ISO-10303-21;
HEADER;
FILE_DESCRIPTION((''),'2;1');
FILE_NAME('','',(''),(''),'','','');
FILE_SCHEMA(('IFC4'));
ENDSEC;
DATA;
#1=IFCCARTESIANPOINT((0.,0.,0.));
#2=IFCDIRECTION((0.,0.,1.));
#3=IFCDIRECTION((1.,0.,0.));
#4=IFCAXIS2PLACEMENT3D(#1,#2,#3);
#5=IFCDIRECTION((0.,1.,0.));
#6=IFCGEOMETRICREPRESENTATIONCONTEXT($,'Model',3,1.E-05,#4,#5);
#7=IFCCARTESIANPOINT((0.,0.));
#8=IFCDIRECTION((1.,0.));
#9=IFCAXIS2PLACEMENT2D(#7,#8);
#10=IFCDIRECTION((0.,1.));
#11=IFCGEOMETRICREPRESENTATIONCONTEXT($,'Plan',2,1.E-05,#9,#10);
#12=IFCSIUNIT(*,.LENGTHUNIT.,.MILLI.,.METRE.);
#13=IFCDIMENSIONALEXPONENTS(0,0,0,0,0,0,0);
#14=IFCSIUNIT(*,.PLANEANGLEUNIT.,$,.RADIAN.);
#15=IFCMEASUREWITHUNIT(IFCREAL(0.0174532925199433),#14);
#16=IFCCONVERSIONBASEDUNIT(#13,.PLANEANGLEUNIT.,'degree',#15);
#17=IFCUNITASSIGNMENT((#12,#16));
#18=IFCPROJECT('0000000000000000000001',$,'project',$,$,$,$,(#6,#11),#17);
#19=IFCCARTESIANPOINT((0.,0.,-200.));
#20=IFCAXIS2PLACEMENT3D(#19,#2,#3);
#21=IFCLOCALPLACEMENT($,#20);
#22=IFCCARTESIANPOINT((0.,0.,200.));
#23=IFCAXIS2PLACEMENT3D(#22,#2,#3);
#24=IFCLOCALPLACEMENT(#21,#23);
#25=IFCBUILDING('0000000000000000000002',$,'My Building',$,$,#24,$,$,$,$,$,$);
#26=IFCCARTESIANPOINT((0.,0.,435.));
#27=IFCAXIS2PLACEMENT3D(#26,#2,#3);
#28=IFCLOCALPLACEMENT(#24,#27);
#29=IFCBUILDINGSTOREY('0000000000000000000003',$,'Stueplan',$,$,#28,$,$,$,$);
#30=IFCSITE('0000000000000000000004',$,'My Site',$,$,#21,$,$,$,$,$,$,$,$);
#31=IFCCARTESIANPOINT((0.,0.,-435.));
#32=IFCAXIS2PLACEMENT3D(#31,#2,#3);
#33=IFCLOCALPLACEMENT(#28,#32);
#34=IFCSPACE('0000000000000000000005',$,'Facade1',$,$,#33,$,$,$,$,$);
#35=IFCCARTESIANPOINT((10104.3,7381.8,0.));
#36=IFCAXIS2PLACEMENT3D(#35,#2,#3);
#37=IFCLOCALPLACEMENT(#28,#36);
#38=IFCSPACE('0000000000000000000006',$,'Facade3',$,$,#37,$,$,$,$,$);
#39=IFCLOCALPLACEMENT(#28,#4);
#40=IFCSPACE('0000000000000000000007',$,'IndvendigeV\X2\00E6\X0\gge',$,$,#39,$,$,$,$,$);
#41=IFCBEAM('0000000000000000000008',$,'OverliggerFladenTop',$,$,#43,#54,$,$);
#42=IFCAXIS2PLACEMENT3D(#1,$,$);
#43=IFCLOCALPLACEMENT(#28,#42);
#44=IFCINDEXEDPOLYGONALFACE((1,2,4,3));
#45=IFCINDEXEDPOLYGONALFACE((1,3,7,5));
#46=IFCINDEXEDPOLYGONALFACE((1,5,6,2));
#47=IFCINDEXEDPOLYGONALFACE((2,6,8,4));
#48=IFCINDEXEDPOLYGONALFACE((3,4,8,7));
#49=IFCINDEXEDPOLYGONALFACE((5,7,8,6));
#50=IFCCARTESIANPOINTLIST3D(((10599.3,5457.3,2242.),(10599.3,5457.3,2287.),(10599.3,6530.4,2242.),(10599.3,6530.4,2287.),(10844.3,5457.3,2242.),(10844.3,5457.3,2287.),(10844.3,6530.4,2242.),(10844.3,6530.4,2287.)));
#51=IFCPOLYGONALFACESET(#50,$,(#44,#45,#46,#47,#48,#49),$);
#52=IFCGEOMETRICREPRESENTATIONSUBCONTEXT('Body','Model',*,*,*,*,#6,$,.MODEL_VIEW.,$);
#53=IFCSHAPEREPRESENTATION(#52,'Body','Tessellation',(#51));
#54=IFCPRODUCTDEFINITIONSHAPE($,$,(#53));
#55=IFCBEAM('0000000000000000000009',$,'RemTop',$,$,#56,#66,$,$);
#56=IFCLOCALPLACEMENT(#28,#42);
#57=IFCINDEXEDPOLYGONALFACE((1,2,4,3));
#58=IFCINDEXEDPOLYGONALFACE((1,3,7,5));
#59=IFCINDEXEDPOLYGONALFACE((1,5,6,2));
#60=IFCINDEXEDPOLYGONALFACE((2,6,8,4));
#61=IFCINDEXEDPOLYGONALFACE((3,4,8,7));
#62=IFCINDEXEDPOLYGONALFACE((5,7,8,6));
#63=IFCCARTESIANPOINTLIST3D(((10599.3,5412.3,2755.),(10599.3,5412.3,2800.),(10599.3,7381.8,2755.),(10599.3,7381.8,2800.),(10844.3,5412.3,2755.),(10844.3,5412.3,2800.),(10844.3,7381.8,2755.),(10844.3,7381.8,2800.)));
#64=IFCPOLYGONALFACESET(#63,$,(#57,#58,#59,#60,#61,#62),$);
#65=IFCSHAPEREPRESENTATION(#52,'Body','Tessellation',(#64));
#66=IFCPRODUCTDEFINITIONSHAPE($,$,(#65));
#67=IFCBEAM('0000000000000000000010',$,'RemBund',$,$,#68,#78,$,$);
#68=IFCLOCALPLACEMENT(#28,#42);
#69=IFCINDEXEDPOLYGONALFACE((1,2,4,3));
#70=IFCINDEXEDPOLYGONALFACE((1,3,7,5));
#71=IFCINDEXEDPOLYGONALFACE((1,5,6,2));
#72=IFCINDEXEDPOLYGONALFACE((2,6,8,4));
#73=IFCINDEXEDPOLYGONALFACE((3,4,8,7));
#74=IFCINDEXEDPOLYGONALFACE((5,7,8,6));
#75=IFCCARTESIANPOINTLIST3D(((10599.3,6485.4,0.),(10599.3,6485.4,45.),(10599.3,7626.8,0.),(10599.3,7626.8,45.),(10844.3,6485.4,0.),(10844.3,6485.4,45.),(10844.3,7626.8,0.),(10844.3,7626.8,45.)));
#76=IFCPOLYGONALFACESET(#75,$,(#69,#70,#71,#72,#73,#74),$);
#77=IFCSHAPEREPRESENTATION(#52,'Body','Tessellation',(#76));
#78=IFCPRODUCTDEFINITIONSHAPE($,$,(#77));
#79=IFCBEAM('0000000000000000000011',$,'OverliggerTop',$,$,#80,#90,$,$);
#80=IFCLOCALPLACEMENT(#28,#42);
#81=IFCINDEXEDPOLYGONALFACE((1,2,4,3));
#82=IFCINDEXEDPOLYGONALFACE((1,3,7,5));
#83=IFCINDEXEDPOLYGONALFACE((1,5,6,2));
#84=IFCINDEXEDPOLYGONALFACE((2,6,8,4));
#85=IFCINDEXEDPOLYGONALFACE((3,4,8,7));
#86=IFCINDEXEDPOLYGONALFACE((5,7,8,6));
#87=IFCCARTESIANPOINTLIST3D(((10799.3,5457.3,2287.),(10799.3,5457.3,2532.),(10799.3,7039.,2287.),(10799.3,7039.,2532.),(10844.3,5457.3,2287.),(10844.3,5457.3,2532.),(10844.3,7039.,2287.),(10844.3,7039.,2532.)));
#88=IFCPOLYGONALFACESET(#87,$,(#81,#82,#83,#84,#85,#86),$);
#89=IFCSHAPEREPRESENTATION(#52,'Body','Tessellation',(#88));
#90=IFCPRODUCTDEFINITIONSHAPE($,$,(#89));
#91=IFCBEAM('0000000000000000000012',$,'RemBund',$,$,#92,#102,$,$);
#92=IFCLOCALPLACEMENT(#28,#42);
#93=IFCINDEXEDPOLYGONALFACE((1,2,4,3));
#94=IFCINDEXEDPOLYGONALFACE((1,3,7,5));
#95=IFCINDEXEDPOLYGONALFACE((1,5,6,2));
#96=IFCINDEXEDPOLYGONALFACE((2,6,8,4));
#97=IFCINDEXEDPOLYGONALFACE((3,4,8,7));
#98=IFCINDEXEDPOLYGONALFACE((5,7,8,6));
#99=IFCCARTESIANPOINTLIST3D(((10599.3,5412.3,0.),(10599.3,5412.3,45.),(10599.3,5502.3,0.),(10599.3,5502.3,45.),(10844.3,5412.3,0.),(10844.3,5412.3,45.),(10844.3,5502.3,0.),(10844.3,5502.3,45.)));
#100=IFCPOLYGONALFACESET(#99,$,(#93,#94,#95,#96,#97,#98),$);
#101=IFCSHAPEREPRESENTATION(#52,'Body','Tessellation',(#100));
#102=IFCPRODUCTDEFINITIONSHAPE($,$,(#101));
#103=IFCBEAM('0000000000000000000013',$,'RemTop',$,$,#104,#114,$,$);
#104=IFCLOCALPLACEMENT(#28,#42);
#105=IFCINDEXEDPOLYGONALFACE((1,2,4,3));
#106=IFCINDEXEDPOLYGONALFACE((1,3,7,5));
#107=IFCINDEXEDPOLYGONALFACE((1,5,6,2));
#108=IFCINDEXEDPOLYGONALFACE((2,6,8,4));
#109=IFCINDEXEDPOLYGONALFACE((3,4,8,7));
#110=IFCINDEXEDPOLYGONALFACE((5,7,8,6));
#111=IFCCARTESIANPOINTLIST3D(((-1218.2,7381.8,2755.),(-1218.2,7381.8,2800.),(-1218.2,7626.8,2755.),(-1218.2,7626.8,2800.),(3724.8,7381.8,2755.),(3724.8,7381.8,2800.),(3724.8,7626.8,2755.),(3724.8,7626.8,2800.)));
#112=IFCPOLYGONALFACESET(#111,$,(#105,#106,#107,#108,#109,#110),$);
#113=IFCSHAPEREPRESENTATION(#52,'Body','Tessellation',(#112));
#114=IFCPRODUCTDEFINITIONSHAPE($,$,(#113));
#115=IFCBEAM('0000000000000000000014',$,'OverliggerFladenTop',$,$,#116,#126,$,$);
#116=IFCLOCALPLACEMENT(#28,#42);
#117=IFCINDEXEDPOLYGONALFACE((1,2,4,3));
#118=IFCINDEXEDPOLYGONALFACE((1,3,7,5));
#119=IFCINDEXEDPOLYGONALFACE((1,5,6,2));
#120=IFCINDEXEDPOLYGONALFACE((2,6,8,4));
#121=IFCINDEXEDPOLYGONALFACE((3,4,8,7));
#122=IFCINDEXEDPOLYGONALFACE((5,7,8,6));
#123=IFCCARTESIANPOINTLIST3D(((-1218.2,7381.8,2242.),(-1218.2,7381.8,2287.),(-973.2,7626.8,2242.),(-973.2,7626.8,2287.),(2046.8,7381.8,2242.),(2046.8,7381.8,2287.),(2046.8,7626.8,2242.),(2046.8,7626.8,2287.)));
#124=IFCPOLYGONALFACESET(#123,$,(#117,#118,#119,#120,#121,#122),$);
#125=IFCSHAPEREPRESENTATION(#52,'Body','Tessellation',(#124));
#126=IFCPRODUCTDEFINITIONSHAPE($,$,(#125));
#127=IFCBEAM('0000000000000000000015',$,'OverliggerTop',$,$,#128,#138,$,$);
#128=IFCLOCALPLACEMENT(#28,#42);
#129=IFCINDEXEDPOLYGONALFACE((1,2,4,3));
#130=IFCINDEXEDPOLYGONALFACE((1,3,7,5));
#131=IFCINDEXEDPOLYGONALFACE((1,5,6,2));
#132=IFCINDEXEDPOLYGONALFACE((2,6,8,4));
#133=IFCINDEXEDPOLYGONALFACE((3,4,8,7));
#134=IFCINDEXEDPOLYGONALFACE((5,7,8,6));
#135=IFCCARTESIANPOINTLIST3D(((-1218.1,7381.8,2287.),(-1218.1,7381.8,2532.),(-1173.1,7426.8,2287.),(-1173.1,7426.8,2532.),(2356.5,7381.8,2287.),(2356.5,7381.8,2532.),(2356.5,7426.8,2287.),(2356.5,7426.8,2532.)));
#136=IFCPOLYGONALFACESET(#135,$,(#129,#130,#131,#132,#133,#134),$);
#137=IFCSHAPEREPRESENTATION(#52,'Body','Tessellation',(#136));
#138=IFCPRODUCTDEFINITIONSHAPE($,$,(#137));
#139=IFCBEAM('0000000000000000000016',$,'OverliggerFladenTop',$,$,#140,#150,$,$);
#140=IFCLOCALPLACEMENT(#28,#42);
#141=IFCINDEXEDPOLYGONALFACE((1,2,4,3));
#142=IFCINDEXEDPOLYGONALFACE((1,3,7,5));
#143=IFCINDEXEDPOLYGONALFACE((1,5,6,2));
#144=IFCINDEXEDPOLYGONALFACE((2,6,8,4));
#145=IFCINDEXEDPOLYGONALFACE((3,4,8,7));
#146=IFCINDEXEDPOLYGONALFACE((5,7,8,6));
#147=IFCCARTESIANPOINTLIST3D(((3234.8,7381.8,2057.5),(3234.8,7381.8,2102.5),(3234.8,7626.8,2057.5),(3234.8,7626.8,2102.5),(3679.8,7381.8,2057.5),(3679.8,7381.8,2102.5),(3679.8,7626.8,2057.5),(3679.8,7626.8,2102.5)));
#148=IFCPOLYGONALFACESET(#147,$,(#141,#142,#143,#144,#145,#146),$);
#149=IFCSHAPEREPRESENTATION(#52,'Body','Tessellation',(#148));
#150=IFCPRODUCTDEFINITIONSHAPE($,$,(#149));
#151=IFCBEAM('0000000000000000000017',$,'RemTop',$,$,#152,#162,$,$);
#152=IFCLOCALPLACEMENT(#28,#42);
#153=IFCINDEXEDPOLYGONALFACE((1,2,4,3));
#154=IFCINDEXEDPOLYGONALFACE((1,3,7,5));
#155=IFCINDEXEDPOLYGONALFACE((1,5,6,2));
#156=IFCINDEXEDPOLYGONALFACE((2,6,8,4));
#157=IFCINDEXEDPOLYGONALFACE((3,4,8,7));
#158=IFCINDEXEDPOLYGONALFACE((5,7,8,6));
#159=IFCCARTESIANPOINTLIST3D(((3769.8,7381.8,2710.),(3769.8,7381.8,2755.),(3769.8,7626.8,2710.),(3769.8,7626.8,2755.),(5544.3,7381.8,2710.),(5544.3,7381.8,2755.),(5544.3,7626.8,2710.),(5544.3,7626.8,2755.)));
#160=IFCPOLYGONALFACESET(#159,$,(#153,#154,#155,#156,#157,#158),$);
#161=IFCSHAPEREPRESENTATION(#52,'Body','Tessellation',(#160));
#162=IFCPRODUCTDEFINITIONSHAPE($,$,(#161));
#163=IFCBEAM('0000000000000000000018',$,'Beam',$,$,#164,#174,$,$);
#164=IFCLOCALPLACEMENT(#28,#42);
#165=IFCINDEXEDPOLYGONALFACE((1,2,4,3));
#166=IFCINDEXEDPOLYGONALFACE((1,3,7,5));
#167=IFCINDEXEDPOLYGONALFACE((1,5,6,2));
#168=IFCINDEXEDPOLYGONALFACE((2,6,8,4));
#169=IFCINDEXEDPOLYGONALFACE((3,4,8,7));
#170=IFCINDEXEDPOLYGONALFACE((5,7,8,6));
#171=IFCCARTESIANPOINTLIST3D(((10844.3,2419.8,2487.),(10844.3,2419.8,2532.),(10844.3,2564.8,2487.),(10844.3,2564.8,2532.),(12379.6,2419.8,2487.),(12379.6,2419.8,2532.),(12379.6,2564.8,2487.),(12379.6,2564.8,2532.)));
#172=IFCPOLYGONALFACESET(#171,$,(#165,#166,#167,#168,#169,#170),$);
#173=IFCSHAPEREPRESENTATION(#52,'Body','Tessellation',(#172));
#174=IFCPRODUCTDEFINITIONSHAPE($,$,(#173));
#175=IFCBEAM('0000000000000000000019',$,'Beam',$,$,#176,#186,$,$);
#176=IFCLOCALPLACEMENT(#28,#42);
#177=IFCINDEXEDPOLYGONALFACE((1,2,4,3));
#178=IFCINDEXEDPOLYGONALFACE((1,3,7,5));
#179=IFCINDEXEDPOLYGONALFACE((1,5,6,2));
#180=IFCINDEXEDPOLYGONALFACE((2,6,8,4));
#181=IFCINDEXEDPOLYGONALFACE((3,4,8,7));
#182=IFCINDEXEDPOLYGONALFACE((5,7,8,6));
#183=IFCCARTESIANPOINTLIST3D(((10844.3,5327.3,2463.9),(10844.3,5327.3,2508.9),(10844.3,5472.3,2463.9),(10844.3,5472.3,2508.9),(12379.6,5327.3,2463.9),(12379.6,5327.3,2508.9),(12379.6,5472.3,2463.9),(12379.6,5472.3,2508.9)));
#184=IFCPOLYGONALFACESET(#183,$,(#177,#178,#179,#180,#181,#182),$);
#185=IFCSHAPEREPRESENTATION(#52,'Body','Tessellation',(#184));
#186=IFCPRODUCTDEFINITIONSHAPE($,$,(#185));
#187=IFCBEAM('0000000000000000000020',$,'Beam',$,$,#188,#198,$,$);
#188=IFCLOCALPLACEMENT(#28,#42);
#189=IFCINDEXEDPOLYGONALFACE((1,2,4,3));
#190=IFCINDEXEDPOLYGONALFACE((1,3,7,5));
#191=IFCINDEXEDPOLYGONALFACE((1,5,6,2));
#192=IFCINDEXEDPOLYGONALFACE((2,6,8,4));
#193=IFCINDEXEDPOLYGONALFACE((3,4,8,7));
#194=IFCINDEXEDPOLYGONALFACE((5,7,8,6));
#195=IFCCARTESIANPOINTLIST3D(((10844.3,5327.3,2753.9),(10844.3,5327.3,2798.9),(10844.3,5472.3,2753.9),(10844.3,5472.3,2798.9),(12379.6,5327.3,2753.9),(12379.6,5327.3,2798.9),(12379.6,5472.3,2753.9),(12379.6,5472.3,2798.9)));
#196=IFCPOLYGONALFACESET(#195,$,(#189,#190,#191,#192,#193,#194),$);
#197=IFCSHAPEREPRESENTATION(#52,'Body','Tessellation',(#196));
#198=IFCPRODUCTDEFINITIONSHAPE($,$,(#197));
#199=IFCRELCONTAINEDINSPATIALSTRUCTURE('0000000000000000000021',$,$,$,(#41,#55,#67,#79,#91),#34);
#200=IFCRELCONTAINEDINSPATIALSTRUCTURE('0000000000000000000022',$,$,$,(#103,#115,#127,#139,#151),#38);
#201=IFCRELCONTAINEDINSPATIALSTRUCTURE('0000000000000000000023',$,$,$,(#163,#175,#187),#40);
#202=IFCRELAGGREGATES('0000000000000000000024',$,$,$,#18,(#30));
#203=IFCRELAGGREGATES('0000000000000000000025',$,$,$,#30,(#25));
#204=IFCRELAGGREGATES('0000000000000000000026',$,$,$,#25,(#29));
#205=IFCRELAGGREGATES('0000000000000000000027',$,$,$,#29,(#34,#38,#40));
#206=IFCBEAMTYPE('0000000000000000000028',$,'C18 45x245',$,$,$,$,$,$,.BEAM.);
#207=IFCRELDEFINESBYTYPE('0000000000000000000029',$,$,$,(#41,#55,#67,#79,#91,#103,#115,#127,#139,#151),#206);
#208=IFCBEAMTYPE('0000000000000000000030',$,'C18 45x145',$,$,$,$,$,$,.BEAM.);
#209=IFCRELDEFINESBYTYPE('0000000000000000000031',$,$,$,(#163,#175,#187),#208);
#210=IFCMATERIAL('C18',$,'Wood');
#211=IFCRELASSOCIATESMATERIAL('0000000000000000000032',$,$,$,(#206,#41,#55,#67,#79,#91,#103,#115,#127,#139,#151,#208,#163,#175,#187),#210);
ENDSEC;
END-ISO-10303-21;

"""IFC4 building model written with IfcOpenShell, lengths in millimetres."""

from ifc_helpers import new_model, entity, si_unit, converted_unit, direction, frame, origin_with_axes, origin_2d_with_axis, place, context, subcontext, project, spatial, rectangle, extrude, clip, halfspace, material, material_profile, profile_set, profile_usage, type_object, element, save


model = new_model("IFC4")

# Units and contexts
model_context = context("Model", 3, precision=1e-05, world=origin_with_axes(), true_north=direction((0.0, 1.0, 0.0)))
plan_context = context("Plan", 2, precision=1e-05, world=origin_2d_with_axis(), true_north=direction((0.0, 1.0)))
body_context_1 = subcontext(model_context, "Body", "Model", "MODEL_VIEW")
ifc_project = project(units=[si_unit("LENGTHUNIT", "METRE", prefix="MILLI"), converted_unit("PLANEANGLEUNIT", "degree", entity("IfcReal", 0.0174532925199433), si_unit("PLANEANGLEUNIT", "RADIAN"), dimensions=[0, 0, 0, 0, 0, 0, 0])], contexts=[model_context, plan_context])

# Site, building, storey, space
site_placement = place(None, frame((0.0, 0.0, -200.0), z_axis=(0.0, 0.0, 1.0), x_axis=(1.0, 0.0, 0.0)))
site = spatial("IfcSite", under=ifc_project, at=site_placement, Name="My Site")
building_placement = place(site_placement, frame((0.0, 0.0, 200.0), z_axis=(0.0, 0.0, 1.0), x_axis=(1.0, 0.0, 0.0)))
building = spatial("IfcBuilding", under=site, at=building_placement, Name="My Building")
storey_placement = place(building_placement, frame((0.0, 0.0, 435.0), z_axis=(0.0, 0.0, 1.0), x_axis=(1.0, 0.0, 0.0)))
storey = spatial("IfcBuildingStorey", under=building, at=storey_placement, Name="Stueplan")
space_1_placement = place(storey_placement, frame((0.0, 0.0, -435.0), z_axis=(0.0, 0.0, 1.0), x_axis=(1.0, 0.0, 0.0)))
space_1 = spatial("IfcSpace", under=storey, at=space_1_placement, Name="Facade1")

# Shared definitions
ifc_material_1 = material(Name="C18", Category="Wood")

# Beams
ifc_material_profile_1 = material_profile(ifc_material_1, rectangle(XDim=45.0, YDim=245.0), Name="concrete")
ifc_profile_set_1 = profile_set([ifc_material_profile_1], Name="woodStructural")
ifc_profile_usage_1 = profile_usage(ifc_profile_set_1)
beam_type_1 = type_object("IfcBeamType", Name="C18 45x245", PredefinedType="BEAM", material=ifc_profile_set_1)
beam_1_placement = place(space_1_placement, frame((10721.8, 5457.3, 2699.5), z_axis=(0.0, 1.0, 0.0), x_axis=(0.0, 0.0, 1.0)))
element("IfcBeam", 1, at=beam_1_placement, inside=space_1, type_object=beam_type_1, material=ifc_profile_usage_1, Name="OverliggerFladenTop", context=body_context_1, shape_type="SweptSolid", body=[
    extrude(rectangle(XDim=45.0, YDim=245.0), origin_with_axes(), (0.0, 0.0, 1.0), 1073.1),
])
ifc_profile_usage_2 = profile_usage(ifc_profile_set_1)
beam_2_placement = place(space_1_placement, frame((10721.8, 5412.3, 3212.5), z_axis=(0.0, 1.0, 0.0), x_axis=(0.0, 0.0, 1.0)))
element("IfcBeam", 2, at=beam_2_placement, inside=space_1, type_object=beam_type_1, material=ifc_profile_usage_2, Name="RemTop", context=body_context_1, shape_type="SweptSolid", body=[
    extrude(rectangle(XDim=45.0, YDim=245.0), origin_with_axes(), (0.0, 0.0, 1.0), 1969.5),
])
ifc_profile_usage_3 = profile_usage(ifc_profile_set_1)
beam_3_placement = place(space_1_placement, frame((10721.8, 6485.4, 457.5), z_axis=(0.0, 1.0, 0.0), x_axis=(0.0, 0.0, 1.0)))
element("IfcBeam", 3, at=beam_3_placement, inside=space_1, type_object=beam_type_1, material=ifc_profile_usage_3, Name="RemBund", context=body_context_1, shape_type="SweptSolid", body=[
    extrude(rectangle(XDim=45.0, YDim=245.0), origin_with_axes(), (0.0, 0.0, 1.0), 1141.4),
])
ifc_profile_usage_4 = profile_usage(ifc_profile_set_1)
beam_4_placement = place(space_1_placement, frame((10821.8, 5457.3, 2844.5), z_axis=(0.0, 1.0, 0.0), x_axis=(1.0, 0.0, 0.0)))
element("IfcBeam", 4, at=beam_4_placement, inside=space_1, type_object=beam_type_1, material=ifc_profile_usage_4, Name="OverliggerTop", context=body_context_1, shape_type="SweptSolid", body=[
    extrude(rectangle(XDim=45.0, YDim=245.0), origin_with_axes(), (0.0, 0.0, 1.0), 1581.7),
])
ifc_profile_usage_5 = profile_usage(ifc_profile_set_1)
beam_5_placement = place(space_1_placement, frame((10721.8, 5412.3, 457.5), z_axis=(0.0, 1.0, 0.0), x_axis=(0.0, 0.0, 1.0)))
element("IfcBeam", 5, at=beam_5_placement, inside=space_1, type_object=beam_type_1, material=ifc_profile_usage_5, Name="RemBund", context=body_context_1, shape_type="SweptSolid", body=[
    extrude(rectangle(XDim=45.0, YDim=245.0), origin_with_axes(), (0.0, 0.0, 1.0), 90.0),
])

# Shared definitions
space_2_placement = place(storey_placement, frame((10104.3, 7381.8, 0.0), z_axis=(0.0, 0.0, 1.0), x_axis=(1.0, 0.0, 0.0)))
space_2 = spatial("IfcSpace", under=storey, at=space_2_placement, Name="Facade3")

# Beams
ifc_profile_usage_6 = profile_usage(ifc_profile_set_1)
beam_6_placement = place(space_2_placement, frame((-6379.6, 122.5, 2777.5), z_axis=(-1.0, 0.0, 0.0), x_axis=(0.0, 0.0, 1.0)))
element("IfcBeam", 6, at=beam_6_placement, inside=space_2, type_object=beam_type_1, material=ifc_profile_usage_6, Name="RemTop", context=body_context_1, shape_type="SweptSolid", body=[
    extrude(rectangle(XDim=45.0, YDim=245.0), origin_with_axes(), (0.0, 0.0, 1.0), 4942.9),
])
ifc_profile_usage_7 = profile_usage(ifc_profile_set_1)
beam_7_placement = place(space_2_placement, frame((-8057.5, 122.5, 2264.5), z_axis=(-1.0, 0.0, 0.0), x_axis=(0.0, 0.0, 1.0)))
element("IfcBeam", 7, at=beam_7_placement, inside=space_2, type_object=beam_type_1, material=ifc_profile_usage_7, Name="OverliggerFladenTop", context=body_context_1, shape_type="Clipping", body=[
    clip(extrude(rectangle(XDim=45.0, YDim=245.0), origin_with_axes(), (0.0, 0.0, 1.0), 3265.0), halfspace(frame((-2699.5, -122.5, 3265.0), z_axis=(0.0, 0.707107, 0.707107), x_axis=(1.0, 0.0, 0.0)), False)),
])
ifc_profile_usage_8 = profile_usage(ifc_profile_set_1)
beam_8_placement = place(space_2_placement, frame((-7747.9, 22.5, 2409.5), z_axis=(-1.0, 0.0, 0.0), x_axis=(0.0, 1.0, 0.0)))
element("IfcBeam", 8, at=beam_8_placement, inside=space_2, type_object=beam_type_1, material=ifc_profile_usage_8, Name="OverliggerTop", context=body_context_1, shape_type="Clipping", body=[
    clip(extrude(rectangle(XDim=45.0, YDim=245.0), origin_with_axes(), (0.0, 0.0, 1.0), 3574.6), halfspace(frame((-22.5, 2844.5, 3574.6), z_axis=(0.707107, 0.0, 0.707107), x_axis=(0.0, -1.0, 0.0)), False)),
])
ifc_profile_usage_9 = profile_usage(ifc_profile_set_1)
beam_9_placement = place(space_2_placement, frame((-6424.6, 122.5, 2080.0), z_axis=(-1.0, 0.0, 0.0), x_axis=(0.0, 0.0, 1.0)))
element("IfcBeam", 9, at=beam_9_placement, inside=space_2, type_object=beam_type_1, material=ifc_profile_usage_9, Name="OverliggerFladenTop", context=body_context_1, shape_type="SweptSolid", body=[
    extrude(rectangle(XDim=45.0, YDim=245.0), origin_with_axes(), (0.0, 0.0, 1.0), 445.0),
])
ifc_profile_usage_10 = profile_usage(ifc_profile_set_1)
beam_10_placement = place(space_2_placement, frame((-4560.1, 122.5, 2732.5), z_axis=(-1.0, 0.0, 0.0), x_axis=(0.0, 0.0, 1.0)))
element("IfcBeam", 10, at=beam_10_placement, inside=space_2, type_object=beam_type_1, material=ifc_profile_usage_10, Name="RemTop", context=body_context_1, shape_type="SweptSolid", body=[
    extrude(rectangle(XDim=45.0, YDim=245.0), origin_with_axes(), (0.0, 0.0, 1.0), 1774.5),
])

# Shared definitions
space_3_placement = place(storey_placement, frame((0.0, 0.0, 0.0), z_axis=(0.0, 0.0, 1.0), x_axis=(1.0, 0.0, 0.0)))
space_3 = spatial("IfcSpace", under=storey, at=space_3_placement, Name="IndvendigeVægge")

# Beams
ifc_material_profile_2 = material_profile(ifc_material_1, rectangle(XDim=45.0, YDim=145.0))
ifc_profile_set_2 = profile_set([ifc_material_profile_2], Name="woodStructural")
ifc_profile_usage_11 = profile_usage(ifc_profile_set_2)
beam_type_2 = type_object("IfcBeamType", Name="C18 45x145", PredefinedType="BEAM", material=ifc_profile_set_2)
beam_11_placement = place(space_3_placement, frame((10844.3, 2492.3, 2509.5), z_axis=(1.0, 0.0, 0.0), x_axis=(0.0, 0.0, 1.0)))
element("IfcBeam", 11, at=beam_11_placement, inside=space_3, type_object=beam_type_2, material=ifc_profile_usage_11, Name="Beam", context=body_context_1, shape_type="SweptSolid", body=[
    extrude(rectangle(XDim=45.0, YDim=145.0), origin_with_axes(), (0.0, 0.0, 1.0), 1535.3),
])
ifc_profile_usage_12 = profile_usage(ifc_profile_set_2)
beam_12_placement = place(space_3_placement, frame((10844.3, 5399.8, 2486.4), z_axis=(1.0, 0.0, 0.0), x_axis=(0.0, 0.0, 1.0)))
element("IfcBeam", 12, at=beam_12_placement, inside=space_3, type_object=beam_type_2, material=ifc_profile_usage_12, Name="Beam", context=body_context_1, shape_type="SweptSolid", body=[
    extrude(rectangle(XDim=45.0, YDim=145.0), origin_with_axes(), (0.0, 0.0, 1.0), 1535.3),
])
ifc_profile_usage_13 = profile_usage(ifc_profile_set_2)
beam_13_placement = place(space_3_placement, frame((10844.3, 5399.8, 2776.4), z_axis=(1.0, 0.0, 0.0), x_axis=(0.0, 0.0, 1.0)))
element("IfcBeam", 13, at=beam_13_placement, inside=space_3, type_object=beam_type_2, material=ifc_profile_usage_13, Name="Beam", context=body_context_1, shape_type="SweptSolid", body=[
    extrude(rectangle(XDim=45.0, YDim=145.0), origin_with_axes(), (0.0, 0.0, 1.0), 1535.3),
])

save(model, "model.ifc")
